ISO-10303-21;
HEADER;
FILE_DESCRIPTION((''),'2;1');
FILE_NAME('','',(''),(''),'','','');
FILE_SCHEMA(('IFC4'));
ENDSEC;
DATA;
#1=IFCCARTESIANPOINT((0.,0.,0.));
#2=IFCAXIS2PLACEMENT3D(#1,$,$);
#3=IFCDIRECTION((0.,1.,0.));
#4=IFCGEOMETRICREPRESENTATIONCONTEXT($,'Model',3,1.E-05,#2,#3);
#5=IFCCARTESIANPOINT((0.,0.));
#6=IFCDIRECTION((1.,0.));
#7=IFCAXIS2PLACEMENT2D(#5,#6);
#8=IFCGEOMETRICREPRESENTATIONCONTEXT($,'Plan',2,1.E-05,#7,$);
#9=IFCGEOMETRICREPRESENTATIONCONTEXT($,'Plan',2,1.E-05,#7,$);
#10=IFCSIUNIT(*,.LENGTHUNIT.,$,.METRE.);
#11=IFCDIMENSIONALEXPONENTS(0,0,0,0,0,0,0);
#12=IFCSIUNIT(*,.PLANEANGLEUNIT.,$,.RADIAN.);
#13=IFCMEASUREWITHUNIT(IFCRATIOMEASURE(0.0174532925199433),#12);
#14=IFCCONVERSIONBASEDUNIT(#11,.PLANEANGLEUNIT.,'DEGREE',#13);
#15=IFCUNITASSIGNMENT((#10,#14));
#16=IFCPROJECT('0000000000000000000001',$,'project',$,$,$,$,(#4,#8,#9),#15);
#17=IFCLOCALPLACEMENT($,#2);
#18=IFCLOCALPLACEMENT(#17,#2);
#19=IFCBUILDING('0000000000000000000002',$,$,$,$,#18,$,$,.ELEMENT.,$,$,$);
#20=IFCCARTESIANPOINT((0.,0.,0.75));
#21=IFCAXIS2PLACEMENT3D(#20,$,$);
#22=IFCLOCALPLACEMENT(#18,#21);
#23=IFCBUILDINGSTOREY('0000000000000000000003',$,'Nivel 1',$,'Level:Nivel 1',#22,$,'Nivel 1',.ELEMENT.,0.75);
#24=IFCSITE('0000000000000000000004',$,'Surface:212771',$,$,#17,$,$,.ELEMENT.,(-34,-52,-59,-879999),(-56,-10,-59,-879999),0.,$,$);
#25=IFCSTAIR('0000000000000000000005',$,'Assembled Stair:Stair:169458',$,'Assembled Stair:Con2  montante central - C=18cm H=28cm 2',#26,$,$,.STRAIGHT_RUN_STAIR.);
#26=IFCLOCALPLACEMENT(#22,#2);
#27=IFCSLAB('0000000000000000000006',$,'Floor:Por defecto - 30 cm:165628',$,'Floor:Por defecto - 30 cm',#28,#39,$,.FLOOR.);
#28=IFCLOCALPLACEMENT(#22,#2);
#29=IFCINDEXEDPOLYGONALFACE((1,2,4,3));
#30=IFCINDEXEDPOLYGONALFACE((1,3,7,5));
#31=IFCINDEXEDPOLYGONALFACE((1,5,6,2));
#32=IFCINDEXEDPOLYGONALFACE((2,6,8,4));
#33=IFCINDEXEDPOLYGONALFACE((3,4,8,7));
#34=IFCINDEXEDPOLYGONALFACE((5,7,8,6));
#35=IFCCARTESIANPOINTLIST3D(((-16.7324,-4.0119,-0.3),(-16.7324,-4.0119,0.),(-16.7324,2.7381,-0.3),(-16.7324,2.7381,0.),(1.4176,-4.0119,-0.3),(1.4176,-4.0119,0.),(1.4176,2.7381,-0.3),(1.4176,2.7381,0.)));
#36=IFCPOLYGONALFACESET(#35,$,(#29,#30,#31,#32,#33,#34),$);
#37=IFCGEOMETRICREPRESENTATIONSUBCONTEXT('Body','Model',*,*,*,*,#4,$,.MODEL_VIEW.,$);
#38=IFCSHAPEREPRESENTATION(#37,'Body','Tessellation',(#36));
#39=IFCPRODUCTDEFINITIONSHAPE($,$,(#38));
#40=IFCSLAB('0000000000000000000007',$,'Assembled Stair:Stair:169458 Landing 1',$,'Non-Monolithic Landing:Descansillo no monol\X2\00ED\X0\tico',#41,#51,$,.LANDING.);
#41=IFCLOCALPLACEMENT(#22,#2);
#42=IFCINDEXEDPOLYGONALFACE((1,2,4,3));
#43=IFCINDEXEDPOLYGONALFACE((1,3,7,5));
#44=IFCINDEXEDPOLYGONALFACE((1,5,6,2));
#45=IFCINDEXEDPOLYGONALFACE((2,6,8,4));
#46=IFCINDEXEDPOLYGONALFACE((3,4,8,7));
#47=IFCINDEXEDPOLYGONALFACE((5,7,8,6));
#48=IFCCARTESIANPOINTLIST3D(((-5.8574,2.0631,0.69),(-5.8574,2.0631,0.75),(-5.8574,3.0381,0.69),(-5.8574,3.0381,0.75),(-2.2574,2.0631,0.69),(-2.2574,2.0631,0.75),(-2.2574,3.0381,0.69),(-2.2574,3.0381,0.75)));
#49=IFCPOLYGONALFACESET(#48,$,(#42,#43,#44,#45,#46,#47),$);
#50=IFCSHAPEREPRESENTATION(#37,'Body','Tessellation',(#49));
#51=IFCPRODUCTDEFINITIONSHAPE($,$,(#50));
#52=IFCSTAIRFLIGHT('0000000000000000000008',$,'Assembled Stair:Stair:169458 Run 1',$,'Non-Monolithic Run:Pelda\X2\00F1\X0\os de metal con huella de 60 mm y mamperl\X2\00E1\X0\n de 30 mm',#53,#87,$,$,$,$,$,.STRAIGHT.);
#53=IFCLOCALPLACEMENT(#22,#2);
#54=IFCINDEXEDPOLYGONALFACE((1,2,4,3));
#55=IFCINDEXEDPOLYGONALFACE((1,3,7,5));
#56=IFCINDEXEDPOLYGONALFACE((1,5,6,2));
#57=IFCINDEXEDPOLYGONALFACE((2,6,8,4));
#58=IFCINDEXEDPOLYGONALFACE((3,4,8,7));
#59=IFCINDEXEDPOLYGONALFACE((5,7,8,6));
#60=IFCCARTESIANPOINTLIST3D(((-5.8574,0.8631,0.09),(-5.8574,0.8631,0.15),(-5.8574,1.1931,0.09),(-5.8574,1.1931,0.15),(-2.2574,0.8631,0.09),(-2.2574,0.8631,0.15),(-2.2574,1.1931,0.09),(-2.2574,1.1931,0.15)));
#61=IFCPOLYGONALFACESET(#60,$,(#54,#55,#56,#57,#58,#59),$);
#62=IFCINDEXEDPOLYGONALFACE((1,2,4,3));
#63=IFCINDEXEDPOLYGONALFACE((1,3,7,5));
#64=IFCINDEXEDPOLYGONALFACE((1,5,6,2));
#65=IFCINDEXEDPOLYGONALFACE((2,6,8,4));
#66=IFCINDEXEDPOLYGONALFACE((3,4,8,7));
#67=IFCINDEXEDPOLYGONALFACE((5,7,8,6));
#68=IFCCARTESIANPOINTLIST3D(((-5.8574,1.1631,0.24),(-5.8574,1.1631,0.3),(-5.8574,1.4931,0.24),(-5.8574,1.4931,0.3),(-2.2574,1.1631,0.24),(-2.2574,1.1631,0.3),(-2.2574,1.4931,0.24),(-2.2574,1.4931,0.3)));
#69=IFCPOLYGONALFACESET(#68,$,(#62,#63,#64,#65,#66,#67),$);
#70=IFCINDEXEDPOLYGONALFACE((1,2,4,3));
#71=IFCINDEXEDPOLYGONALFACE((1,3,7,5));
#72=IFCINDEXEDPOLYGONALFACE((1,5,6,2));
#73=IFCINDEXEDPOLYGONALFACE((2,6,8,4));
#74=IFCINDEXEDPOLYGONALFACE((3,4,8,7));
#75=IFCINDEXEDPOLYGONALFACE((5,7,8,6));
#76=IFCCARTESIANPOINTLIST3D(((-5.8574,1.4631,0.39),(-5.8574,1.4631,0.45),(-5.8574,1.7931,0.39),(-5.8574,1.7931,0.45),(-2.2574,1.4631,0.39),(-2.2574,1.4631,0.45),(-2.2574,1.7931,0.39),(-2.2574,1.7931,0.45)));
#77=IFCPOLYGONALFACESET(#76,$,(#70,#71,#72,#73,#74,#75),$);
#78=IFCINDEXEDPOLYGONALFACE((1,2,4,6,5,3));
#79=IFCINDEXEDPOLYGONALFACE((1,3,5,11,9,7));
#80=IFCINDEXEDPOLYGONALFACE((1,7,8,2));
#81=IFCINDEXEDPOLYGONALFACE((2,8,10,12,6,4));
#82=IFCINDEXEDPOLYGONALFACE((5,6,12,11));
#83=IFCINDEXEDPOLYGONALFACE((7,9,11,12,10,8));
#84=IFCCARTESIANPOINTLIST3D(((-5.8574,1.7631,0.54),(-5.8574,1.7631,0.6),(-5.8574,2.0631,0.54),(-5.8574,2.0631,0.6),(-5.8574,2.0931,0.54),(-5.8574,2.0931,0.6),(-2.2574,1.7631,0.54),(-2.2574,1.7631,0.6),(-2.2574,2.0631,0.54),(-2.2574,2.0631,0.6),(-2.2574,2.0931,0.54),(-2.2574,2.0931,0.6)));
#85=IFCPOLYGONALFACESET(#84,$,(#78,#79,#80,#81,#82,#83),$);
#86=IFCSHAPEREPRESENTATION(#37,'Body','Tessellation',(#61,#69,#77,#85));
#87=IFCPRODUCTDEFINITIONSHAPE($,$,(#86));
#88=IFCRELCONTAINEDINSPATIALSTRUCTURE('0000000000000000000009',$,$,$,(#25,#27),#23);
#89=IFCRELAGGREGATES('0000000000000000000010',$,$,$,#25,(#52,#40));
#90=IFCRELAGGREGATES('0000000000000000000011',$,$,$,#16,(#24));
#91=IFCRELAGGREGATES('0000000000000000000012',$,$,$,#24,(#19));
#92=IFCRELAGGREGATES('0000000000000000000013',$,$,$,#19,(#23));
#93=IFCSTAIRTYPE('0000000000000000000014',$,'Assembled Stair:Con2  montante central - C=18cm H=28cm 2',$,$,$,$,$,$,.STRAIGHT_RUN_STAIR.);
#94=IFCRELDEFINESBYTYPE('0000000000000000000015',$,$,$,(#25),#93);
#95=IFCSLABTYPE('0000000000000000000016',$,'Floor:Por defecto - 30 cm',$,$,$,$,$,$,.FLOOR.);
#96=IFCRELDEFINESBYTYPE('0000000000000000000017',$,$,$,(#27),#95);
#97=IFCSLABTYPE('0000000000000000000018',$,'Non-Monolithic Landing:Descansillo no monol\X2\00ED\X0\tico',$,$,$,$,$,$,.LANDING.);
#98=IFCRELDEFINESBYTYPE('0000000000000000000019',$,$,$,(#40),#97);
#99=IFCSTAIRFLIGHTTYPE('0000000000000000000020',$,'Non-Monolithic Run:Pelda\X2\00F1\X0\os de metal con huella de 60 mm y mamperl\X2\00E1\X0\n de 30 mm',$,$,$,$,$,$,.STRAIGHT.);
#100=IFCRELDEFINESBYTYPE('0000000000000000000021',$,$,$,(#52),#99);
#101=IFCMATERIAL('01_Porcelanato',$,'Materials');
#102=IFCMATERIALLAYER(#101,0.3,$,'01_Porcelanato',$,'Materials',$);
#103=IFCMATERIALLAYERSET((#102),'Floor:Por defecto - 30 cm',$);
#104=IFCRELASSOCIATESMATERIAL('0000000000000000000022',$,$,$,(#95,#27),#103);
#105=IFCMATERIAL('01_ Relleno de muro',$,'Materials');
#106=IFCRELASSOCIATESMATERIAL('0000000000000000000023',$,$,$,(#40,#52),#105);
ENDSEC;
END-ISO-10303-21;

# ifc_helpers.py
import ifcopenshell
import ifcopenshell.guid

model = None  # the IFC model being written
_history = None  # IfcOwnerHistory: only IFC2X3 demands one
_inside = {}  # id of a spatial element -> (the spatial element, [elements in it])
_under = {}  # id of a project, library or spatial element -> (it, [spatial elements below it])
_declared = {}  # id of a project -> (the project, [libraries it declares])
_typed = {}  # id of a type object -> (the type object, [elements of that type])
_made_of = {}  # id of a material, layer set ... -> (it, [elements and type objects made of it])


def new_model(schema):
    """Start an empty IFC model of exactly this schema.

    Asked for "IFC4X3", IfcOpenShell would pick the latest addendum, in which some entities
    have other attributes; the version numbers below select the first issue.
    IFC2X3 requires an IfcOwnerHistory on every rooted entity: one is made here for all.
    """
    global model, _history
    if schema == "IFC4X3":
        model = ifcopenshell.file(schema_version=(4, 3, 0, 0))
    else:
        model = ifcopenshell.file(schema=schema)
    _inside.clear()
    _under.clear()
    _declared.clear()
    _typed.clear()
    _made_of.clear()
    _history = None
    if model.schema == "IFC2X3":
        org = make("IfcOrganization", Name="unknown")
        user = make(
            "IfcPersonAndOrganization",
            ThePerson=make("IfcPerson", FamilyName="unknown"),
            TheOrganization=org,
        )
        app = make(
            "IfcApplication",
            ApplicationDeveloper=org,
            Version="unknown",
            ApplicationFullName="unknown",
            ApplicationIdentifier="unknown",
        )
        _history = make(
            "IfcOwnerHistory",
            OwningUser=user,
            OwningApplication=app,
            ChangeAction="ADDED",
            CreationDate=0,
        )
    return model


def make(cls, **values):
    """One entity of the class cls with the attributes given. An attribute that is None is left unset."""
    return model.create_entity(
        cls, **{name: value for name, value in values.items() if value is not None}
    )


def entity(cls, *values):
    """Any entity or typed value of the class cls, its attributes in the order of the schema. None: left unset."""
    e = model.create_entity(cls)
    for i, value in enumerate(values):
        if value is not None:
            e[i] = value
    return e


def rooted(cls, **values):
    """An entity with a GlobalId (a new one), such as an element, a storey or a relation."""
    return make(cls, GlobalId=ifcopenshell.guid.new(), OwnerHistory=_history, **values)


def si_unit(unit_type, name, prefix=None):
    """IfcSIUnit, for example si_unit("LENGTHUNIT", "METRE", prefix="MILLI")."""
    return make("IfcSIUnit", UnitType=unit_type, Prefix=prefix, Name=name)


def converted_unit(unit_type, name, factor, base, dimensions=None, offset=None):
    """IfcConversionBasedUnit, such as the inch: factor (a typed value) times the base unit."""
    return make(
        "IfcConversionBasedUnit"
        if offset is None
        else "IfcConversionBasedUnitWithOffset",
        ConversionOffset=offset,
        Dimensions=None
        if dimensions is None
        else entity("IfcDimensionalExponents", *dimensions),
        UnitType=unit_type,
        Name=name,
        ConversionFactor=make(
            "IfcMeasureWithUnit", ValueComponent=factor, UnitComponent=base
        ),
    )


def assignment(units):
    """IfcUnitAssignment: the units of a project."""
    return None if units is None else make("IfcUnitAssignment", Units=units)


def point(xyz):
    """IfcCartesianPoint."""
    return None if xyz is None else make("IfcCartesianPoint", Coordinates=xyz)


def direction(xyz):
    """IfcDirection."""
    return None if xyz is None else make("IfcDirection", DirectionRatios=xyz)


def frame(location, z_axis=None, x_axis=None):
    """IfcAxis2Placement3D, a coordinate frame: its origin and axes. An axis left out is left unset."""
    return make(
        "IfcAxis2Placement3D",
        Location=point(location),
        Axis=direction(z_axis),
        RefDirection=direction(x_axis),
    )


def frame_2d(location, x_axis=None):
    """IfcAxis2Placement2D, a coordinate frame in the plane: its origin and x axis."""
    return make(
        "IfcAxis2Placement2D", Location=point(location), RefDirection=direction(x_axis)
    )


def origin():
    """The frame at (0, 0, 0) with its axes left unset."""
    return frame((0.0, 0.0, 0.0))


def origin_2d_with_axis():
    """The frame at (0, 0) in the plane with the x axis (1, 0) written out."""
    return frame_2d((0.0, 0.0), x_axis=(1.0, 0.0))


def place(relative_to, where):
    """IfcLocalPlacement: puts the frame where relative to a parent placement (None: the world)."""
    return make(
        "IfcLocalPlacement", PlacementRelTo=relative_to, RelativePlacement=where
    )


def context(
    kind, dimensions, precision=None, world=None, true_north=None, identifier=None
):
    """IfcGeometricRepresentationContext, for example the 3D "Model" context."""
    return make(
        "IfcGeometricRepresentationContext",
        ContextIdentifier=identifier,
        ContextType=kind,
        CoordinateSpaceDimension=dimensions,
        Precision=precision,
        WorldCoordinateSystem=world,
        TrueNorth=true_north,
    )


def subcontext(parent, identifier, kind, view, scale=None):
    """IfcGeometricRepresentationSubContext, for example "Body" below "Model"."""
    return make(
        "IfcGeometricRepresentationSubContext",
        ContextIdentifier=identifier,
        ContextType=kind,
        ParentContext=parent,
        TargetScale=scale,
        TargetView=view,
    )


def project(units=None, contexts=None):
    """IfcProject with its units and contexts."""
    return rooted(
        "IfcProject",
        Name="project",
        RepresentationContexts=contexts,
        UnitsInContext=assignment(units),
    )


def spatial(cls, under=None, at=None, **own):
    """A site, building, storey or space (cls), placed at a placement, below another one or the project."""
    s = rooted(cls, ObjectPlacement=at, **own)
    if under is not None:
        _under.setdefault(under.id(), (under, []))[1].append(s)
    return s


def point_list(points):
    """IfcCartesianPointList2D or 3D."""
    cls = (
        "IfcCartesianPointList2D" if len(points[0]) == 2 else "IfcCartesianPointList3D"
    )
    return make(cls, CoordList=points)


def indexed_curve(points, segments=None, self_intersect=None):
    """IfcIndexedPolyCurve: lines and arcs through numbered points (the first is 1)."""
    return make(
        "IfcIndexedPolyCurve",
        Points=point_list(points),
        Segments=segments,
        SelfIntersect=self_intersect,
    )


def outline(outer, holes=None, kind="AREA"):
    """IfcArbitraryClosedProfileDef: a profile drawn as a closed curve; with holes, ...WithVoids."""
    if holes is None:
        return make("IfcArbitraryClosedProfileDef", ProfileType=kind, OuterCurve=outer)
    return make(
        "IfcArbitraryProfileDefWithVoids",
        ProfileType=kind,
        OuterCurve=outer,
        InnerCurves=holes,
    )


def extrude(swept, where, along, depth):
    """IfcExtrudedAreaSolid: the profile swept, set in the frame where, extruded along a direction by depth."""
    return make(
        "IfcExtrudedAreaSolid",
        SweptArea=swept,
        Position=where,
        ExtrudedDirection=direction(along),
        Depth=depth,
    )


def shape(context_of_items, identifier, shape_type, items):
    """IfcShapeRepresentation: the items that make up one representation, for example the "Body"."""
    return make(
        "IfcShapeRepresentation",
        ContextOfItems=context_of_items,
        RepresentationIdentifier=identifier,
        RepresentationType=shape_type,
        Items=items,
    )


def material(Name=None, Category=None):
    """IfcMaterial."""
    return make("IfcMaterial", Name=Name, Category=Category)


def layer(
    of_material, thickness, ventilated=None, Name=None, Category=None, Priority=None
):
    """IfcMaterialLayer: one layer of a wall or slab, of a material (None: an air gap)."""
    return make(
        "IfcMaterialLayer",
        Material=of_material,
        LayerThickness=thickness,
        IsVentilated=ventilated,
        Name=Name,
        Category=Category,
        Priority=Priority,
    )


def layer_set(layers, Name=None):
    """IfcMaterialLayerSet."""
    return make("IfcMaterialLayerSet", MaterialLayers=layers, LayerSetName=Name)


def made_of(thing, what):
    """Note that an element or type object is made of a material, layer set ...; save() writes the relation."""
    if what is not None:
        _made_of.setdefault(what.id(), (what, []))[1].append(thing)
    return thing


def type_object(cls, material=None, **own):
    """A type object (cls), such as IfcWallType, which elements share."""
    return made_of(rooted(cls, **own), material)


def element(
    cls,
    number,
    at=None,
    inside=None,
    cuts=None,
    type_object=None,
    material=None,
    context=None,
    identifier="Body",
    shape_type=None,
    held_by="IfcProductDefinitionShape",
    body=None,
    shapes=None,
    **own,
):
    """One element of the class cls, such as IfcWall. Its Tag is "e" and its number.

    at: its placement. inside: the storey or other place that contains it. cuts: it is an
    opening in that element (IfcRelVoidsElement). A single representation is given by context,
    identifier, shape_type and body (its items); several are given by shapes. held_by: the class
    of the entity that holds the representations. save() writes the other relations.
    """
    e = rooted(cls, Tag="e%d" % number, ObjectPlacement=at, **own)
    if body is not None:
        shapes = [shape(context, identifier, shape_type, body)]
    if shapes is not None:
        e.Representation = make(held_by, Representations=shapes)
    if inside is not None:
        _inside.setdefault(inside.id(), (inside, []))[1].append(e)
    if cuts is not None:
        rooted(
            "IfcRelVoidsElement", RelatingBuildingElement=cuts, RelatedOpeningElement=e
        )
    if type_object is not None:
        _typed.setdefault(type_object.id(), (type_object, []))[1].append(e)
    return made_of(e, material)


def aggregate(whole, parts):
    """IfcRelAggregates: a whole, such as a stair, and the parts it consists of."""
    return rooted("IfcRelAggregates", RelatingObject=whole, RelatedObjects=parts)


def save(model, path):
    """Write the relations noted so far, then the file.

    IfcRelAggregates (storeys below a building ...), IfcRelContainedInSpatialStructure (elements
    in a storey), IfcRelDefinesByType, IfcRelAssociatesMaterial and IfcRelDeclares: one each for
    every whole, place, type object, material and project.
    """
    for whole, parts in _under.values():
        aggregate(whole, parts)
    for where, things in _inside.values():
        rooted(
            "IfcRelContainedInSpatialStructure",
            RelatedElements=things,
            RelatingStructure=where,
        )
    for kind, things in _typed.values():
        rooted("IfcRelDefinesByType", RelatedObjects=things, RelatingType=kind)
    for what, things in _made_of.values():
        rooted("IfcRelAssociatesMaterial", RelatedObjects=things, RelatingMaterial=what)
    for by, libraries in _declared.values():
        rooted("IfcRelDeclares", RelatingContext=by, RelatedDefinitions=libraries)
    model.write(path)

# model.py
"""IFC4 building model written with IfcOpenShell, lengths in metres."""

from ifc_helpers import new_model, entity, si_unit, converted_unit, direction, frame, origin, origin_2d_with_axis, place, context, subcontext, project, spatial, indexed_curve, outline, extrude, material, layer, layer_set, type_object, element, aggregate, save


model = new_model("IFC4")

# Units and contexts
model_context = context("Model", 3, precision=1e-05, world=origin(), true_north=direction((0.0, 1.0, 0.0)))
plan_context_1 = context("Plan", 2, precision=1e-05, world=origin_2d_with_axis())
plan_context_2 = context("Plan", 2, precision=1e-05, world=origin_2d_with_axis())
body_context = subcontext(model_context, "Body", "Model", "MODEL_VIEW")
ifc_project = project(units=[si_unit("LENGTHUNIT", "METRE"), converted_unit("PLANEANGLEUNIT", "DEGREE", entity("IfcRatioMeasure", 0.0174532925199433), si_unit("PLANEANGLEUNIT", "RADIAN"), dimensions=[0, 0, 0, 0, 0, 0, 0])], contexts=[model_context, plan_context_1, plan_context_2])

# Site, building, storey
site_placement = place(None, origin())
site = spatial("IfcSite", under=ifc_project, at=site_placement, Name="Surface:212771", CompositionType="ELEMENT", RefLatitude=(-34, -52, -59, -879999), RefLongitude=(-56, -10, -59, -879999), RefElevation=0.0)
building_placement = place(site_placement, origin())
building = spatial("IfcBuilding", under=site, at=building_placement, CompositionType="ELEMENT")
storey_placement = place(building_placement, frame((0.0, 0.0, 0.75)))
storey = spatial("IfcBuildingStorey", under=building, at=storey_placement, Name="Nivel 1", ObjectType="Level:Nivel 1", LongName="Nivel 1", CompositionType="ELEMENT", Elevation=0.75)

# Stair
stair_type = type_object("IfcStairType", Name="Assembled Stair:Con2  montante central - C=18cm H=28cm 2", PredefinedType="STRAIGHT_RUN_STAIR")
stair_placement = place(storey_placement, origin())
stair = element("IfcStair", 1, at=stair_placement, inside=storey, type_object=stair_type, Name="Assembled Stair:Stair:169458", ObjectType="Assembled Stair:Con2  montante central - C=18cm H=28cm 2", PredefinedType="STRAIGHT_RUN_STAIR")

# Slabs
ifc_material_1 = material(Name="01_Porcelanato", Category="Materials")
ifc_layer = layer(ifc_material_1, 0.3, Name="01_Porcelanato", Category="Materials")
ifc_layer_set = layer_set([ifc_layer], Name="Floor:Por defecto - 30 cm")
slab_type_1 = type_object("IfcSlabType", Name="Floor:Por defecto - 30 cm", PredefinedType="FLOOR", material=ifc_layer_set)
slab_1_placement = place(storey_placement, origin())
element("IfcSlab", 2, at=slab_1_placement, inside=storey, type_object=slab_type_1, material=ifc_layer_set, Name="Floor:Por defecto - 30 cm:165628", ObjectType="Floor:Por defecto - 30 cm", PredefinedType="FLOOR", context=body_context, shape_type="SweptSolid", body=[
    extrude(outline(indexed_curve([(-3.375, -9.075), (3.375, -9.075), (3.375, 9.075), (-3.375, 9.075), (-3.375, -9.075)], self_intersect=False)), frame((-7.6574, -0.6369, 0.0), z_axis=(0.0, 0.0, -1.0), x_axis=(0.0, 1.0, 0.0)), (0.0, 0.0, 1.0), 0.3),
])
ifc_material_2 = material(Name="01_ Relleno de muro", Category="Materials")
slab_type_2 = type_object("IfcSlabType", Name="Non-Monolithic Landing:Descansillo no monolítico", PredefinedType="LANDING")
slab_2_placement = place(stair_placement, origin())
slab_2 = element("IfcSlab", 3, at=slab_2_placement, type_object=slab_type_2, material=ifc_material_2, Name="Assembled Stair:Stair:169458 Landing 1", ObjectType="Non-Monolithic Landing:Descansillo no monolítico", PredefinedType="LANDING", context=body_context, shape_type="SweptSolid", body=[
    extrude(outline(indexed_curve([(-1.8, -0.4875), (1.8, -0.4875), (1.8, 0.4875), (-1.8, 0.4875), (-1.8, -0.4875)], self_intersect=False)), frame((-4.0574, 2.5506, 0.69)), (0.0, 0.0, 1.0), 0.06),
])

# Stair flight
stair_flight_type = type_object("IfcStairFlightType", Name="Non-Monolithic Run:Peldaños de metal con huella de 60 mm y mamperlán de 30 mm", PredefinedType="STRAIGHT")
stair_flight_placement = place(stair_placement, origin())
stair_flight = element("IfcStairFlight", 4, at=stair_flight_placement, type_object=stair_flight_type, material=ifc_material_2, Name="Assembled Stair:Stair:169458 Run 1", ObjectType="Non-Monolithic Run:Peldaños de metal con huella de 60 mm y mamperlán de 30 mm", PredefinedType="STRAIGHT", context=body_context, shape_type="SweptSolid", body=[
    extrude(outline(indexed_curve([(-0.165, -1.8), (0.165, -1.8), (0.165, 1.8), (-0.165, 1.8), (-0.165, -1.8)], self_intersect=False)), frame((-4.0574, 1.0281, 0.09), z_axis=(0.0, 0.0, 1.0), x_axis=(0.0, -1.0, 0.0)), (0.0, 0.0, 1.0), 0.06),
    extrude(outline(indexed_curve([(-0.165, -1.8), (0.165, -1.8), (0.165, 1.8), (-0.165, 1.8), (-0.165, -1.8)], self_intersect=False)), frame((-4.0574, 1.3281, 0.24), z_axis=(0.0, 0.0, 1.0), x_axis=(0.0, -1.0, 0.0)), (0.0, 0.0, 1.0), 0.06),
    extrude(outline(indexed_curve([(-0.165, -1.8), (0.165, -1.8), (0.165, 1.8), (-0.165, 1.8), (-0.165, -1.8)], self_intersect=False)), frame((-4.0574, 1.6281, 0.39), z_axis=(0.0, 0.0, 1.0), x_axis=(0.0, -1.0, 0.0)), (0.0, 0.0, 1.0), 0.06),
    extrude(outline(indexed_curve([(-0.12, -1.8), (-0.09, -1.8), (0.21, -1.8), (0.21, 1.8), (-0.09, 1.8), (-0.12, 1.8), (-0.12, -1.8)], self_intersect=False)), frame((-4.0574, 1.9731, 0.54), z_axis=(0.0, 0.0, 1.0), x_axis=(0.0, -1.0, 0.0)), (0.0, 0.0, 1.0), 0.06),
])
aggregate(stair, [stair_flight, slab_2])

save(model, "model.ifc")
